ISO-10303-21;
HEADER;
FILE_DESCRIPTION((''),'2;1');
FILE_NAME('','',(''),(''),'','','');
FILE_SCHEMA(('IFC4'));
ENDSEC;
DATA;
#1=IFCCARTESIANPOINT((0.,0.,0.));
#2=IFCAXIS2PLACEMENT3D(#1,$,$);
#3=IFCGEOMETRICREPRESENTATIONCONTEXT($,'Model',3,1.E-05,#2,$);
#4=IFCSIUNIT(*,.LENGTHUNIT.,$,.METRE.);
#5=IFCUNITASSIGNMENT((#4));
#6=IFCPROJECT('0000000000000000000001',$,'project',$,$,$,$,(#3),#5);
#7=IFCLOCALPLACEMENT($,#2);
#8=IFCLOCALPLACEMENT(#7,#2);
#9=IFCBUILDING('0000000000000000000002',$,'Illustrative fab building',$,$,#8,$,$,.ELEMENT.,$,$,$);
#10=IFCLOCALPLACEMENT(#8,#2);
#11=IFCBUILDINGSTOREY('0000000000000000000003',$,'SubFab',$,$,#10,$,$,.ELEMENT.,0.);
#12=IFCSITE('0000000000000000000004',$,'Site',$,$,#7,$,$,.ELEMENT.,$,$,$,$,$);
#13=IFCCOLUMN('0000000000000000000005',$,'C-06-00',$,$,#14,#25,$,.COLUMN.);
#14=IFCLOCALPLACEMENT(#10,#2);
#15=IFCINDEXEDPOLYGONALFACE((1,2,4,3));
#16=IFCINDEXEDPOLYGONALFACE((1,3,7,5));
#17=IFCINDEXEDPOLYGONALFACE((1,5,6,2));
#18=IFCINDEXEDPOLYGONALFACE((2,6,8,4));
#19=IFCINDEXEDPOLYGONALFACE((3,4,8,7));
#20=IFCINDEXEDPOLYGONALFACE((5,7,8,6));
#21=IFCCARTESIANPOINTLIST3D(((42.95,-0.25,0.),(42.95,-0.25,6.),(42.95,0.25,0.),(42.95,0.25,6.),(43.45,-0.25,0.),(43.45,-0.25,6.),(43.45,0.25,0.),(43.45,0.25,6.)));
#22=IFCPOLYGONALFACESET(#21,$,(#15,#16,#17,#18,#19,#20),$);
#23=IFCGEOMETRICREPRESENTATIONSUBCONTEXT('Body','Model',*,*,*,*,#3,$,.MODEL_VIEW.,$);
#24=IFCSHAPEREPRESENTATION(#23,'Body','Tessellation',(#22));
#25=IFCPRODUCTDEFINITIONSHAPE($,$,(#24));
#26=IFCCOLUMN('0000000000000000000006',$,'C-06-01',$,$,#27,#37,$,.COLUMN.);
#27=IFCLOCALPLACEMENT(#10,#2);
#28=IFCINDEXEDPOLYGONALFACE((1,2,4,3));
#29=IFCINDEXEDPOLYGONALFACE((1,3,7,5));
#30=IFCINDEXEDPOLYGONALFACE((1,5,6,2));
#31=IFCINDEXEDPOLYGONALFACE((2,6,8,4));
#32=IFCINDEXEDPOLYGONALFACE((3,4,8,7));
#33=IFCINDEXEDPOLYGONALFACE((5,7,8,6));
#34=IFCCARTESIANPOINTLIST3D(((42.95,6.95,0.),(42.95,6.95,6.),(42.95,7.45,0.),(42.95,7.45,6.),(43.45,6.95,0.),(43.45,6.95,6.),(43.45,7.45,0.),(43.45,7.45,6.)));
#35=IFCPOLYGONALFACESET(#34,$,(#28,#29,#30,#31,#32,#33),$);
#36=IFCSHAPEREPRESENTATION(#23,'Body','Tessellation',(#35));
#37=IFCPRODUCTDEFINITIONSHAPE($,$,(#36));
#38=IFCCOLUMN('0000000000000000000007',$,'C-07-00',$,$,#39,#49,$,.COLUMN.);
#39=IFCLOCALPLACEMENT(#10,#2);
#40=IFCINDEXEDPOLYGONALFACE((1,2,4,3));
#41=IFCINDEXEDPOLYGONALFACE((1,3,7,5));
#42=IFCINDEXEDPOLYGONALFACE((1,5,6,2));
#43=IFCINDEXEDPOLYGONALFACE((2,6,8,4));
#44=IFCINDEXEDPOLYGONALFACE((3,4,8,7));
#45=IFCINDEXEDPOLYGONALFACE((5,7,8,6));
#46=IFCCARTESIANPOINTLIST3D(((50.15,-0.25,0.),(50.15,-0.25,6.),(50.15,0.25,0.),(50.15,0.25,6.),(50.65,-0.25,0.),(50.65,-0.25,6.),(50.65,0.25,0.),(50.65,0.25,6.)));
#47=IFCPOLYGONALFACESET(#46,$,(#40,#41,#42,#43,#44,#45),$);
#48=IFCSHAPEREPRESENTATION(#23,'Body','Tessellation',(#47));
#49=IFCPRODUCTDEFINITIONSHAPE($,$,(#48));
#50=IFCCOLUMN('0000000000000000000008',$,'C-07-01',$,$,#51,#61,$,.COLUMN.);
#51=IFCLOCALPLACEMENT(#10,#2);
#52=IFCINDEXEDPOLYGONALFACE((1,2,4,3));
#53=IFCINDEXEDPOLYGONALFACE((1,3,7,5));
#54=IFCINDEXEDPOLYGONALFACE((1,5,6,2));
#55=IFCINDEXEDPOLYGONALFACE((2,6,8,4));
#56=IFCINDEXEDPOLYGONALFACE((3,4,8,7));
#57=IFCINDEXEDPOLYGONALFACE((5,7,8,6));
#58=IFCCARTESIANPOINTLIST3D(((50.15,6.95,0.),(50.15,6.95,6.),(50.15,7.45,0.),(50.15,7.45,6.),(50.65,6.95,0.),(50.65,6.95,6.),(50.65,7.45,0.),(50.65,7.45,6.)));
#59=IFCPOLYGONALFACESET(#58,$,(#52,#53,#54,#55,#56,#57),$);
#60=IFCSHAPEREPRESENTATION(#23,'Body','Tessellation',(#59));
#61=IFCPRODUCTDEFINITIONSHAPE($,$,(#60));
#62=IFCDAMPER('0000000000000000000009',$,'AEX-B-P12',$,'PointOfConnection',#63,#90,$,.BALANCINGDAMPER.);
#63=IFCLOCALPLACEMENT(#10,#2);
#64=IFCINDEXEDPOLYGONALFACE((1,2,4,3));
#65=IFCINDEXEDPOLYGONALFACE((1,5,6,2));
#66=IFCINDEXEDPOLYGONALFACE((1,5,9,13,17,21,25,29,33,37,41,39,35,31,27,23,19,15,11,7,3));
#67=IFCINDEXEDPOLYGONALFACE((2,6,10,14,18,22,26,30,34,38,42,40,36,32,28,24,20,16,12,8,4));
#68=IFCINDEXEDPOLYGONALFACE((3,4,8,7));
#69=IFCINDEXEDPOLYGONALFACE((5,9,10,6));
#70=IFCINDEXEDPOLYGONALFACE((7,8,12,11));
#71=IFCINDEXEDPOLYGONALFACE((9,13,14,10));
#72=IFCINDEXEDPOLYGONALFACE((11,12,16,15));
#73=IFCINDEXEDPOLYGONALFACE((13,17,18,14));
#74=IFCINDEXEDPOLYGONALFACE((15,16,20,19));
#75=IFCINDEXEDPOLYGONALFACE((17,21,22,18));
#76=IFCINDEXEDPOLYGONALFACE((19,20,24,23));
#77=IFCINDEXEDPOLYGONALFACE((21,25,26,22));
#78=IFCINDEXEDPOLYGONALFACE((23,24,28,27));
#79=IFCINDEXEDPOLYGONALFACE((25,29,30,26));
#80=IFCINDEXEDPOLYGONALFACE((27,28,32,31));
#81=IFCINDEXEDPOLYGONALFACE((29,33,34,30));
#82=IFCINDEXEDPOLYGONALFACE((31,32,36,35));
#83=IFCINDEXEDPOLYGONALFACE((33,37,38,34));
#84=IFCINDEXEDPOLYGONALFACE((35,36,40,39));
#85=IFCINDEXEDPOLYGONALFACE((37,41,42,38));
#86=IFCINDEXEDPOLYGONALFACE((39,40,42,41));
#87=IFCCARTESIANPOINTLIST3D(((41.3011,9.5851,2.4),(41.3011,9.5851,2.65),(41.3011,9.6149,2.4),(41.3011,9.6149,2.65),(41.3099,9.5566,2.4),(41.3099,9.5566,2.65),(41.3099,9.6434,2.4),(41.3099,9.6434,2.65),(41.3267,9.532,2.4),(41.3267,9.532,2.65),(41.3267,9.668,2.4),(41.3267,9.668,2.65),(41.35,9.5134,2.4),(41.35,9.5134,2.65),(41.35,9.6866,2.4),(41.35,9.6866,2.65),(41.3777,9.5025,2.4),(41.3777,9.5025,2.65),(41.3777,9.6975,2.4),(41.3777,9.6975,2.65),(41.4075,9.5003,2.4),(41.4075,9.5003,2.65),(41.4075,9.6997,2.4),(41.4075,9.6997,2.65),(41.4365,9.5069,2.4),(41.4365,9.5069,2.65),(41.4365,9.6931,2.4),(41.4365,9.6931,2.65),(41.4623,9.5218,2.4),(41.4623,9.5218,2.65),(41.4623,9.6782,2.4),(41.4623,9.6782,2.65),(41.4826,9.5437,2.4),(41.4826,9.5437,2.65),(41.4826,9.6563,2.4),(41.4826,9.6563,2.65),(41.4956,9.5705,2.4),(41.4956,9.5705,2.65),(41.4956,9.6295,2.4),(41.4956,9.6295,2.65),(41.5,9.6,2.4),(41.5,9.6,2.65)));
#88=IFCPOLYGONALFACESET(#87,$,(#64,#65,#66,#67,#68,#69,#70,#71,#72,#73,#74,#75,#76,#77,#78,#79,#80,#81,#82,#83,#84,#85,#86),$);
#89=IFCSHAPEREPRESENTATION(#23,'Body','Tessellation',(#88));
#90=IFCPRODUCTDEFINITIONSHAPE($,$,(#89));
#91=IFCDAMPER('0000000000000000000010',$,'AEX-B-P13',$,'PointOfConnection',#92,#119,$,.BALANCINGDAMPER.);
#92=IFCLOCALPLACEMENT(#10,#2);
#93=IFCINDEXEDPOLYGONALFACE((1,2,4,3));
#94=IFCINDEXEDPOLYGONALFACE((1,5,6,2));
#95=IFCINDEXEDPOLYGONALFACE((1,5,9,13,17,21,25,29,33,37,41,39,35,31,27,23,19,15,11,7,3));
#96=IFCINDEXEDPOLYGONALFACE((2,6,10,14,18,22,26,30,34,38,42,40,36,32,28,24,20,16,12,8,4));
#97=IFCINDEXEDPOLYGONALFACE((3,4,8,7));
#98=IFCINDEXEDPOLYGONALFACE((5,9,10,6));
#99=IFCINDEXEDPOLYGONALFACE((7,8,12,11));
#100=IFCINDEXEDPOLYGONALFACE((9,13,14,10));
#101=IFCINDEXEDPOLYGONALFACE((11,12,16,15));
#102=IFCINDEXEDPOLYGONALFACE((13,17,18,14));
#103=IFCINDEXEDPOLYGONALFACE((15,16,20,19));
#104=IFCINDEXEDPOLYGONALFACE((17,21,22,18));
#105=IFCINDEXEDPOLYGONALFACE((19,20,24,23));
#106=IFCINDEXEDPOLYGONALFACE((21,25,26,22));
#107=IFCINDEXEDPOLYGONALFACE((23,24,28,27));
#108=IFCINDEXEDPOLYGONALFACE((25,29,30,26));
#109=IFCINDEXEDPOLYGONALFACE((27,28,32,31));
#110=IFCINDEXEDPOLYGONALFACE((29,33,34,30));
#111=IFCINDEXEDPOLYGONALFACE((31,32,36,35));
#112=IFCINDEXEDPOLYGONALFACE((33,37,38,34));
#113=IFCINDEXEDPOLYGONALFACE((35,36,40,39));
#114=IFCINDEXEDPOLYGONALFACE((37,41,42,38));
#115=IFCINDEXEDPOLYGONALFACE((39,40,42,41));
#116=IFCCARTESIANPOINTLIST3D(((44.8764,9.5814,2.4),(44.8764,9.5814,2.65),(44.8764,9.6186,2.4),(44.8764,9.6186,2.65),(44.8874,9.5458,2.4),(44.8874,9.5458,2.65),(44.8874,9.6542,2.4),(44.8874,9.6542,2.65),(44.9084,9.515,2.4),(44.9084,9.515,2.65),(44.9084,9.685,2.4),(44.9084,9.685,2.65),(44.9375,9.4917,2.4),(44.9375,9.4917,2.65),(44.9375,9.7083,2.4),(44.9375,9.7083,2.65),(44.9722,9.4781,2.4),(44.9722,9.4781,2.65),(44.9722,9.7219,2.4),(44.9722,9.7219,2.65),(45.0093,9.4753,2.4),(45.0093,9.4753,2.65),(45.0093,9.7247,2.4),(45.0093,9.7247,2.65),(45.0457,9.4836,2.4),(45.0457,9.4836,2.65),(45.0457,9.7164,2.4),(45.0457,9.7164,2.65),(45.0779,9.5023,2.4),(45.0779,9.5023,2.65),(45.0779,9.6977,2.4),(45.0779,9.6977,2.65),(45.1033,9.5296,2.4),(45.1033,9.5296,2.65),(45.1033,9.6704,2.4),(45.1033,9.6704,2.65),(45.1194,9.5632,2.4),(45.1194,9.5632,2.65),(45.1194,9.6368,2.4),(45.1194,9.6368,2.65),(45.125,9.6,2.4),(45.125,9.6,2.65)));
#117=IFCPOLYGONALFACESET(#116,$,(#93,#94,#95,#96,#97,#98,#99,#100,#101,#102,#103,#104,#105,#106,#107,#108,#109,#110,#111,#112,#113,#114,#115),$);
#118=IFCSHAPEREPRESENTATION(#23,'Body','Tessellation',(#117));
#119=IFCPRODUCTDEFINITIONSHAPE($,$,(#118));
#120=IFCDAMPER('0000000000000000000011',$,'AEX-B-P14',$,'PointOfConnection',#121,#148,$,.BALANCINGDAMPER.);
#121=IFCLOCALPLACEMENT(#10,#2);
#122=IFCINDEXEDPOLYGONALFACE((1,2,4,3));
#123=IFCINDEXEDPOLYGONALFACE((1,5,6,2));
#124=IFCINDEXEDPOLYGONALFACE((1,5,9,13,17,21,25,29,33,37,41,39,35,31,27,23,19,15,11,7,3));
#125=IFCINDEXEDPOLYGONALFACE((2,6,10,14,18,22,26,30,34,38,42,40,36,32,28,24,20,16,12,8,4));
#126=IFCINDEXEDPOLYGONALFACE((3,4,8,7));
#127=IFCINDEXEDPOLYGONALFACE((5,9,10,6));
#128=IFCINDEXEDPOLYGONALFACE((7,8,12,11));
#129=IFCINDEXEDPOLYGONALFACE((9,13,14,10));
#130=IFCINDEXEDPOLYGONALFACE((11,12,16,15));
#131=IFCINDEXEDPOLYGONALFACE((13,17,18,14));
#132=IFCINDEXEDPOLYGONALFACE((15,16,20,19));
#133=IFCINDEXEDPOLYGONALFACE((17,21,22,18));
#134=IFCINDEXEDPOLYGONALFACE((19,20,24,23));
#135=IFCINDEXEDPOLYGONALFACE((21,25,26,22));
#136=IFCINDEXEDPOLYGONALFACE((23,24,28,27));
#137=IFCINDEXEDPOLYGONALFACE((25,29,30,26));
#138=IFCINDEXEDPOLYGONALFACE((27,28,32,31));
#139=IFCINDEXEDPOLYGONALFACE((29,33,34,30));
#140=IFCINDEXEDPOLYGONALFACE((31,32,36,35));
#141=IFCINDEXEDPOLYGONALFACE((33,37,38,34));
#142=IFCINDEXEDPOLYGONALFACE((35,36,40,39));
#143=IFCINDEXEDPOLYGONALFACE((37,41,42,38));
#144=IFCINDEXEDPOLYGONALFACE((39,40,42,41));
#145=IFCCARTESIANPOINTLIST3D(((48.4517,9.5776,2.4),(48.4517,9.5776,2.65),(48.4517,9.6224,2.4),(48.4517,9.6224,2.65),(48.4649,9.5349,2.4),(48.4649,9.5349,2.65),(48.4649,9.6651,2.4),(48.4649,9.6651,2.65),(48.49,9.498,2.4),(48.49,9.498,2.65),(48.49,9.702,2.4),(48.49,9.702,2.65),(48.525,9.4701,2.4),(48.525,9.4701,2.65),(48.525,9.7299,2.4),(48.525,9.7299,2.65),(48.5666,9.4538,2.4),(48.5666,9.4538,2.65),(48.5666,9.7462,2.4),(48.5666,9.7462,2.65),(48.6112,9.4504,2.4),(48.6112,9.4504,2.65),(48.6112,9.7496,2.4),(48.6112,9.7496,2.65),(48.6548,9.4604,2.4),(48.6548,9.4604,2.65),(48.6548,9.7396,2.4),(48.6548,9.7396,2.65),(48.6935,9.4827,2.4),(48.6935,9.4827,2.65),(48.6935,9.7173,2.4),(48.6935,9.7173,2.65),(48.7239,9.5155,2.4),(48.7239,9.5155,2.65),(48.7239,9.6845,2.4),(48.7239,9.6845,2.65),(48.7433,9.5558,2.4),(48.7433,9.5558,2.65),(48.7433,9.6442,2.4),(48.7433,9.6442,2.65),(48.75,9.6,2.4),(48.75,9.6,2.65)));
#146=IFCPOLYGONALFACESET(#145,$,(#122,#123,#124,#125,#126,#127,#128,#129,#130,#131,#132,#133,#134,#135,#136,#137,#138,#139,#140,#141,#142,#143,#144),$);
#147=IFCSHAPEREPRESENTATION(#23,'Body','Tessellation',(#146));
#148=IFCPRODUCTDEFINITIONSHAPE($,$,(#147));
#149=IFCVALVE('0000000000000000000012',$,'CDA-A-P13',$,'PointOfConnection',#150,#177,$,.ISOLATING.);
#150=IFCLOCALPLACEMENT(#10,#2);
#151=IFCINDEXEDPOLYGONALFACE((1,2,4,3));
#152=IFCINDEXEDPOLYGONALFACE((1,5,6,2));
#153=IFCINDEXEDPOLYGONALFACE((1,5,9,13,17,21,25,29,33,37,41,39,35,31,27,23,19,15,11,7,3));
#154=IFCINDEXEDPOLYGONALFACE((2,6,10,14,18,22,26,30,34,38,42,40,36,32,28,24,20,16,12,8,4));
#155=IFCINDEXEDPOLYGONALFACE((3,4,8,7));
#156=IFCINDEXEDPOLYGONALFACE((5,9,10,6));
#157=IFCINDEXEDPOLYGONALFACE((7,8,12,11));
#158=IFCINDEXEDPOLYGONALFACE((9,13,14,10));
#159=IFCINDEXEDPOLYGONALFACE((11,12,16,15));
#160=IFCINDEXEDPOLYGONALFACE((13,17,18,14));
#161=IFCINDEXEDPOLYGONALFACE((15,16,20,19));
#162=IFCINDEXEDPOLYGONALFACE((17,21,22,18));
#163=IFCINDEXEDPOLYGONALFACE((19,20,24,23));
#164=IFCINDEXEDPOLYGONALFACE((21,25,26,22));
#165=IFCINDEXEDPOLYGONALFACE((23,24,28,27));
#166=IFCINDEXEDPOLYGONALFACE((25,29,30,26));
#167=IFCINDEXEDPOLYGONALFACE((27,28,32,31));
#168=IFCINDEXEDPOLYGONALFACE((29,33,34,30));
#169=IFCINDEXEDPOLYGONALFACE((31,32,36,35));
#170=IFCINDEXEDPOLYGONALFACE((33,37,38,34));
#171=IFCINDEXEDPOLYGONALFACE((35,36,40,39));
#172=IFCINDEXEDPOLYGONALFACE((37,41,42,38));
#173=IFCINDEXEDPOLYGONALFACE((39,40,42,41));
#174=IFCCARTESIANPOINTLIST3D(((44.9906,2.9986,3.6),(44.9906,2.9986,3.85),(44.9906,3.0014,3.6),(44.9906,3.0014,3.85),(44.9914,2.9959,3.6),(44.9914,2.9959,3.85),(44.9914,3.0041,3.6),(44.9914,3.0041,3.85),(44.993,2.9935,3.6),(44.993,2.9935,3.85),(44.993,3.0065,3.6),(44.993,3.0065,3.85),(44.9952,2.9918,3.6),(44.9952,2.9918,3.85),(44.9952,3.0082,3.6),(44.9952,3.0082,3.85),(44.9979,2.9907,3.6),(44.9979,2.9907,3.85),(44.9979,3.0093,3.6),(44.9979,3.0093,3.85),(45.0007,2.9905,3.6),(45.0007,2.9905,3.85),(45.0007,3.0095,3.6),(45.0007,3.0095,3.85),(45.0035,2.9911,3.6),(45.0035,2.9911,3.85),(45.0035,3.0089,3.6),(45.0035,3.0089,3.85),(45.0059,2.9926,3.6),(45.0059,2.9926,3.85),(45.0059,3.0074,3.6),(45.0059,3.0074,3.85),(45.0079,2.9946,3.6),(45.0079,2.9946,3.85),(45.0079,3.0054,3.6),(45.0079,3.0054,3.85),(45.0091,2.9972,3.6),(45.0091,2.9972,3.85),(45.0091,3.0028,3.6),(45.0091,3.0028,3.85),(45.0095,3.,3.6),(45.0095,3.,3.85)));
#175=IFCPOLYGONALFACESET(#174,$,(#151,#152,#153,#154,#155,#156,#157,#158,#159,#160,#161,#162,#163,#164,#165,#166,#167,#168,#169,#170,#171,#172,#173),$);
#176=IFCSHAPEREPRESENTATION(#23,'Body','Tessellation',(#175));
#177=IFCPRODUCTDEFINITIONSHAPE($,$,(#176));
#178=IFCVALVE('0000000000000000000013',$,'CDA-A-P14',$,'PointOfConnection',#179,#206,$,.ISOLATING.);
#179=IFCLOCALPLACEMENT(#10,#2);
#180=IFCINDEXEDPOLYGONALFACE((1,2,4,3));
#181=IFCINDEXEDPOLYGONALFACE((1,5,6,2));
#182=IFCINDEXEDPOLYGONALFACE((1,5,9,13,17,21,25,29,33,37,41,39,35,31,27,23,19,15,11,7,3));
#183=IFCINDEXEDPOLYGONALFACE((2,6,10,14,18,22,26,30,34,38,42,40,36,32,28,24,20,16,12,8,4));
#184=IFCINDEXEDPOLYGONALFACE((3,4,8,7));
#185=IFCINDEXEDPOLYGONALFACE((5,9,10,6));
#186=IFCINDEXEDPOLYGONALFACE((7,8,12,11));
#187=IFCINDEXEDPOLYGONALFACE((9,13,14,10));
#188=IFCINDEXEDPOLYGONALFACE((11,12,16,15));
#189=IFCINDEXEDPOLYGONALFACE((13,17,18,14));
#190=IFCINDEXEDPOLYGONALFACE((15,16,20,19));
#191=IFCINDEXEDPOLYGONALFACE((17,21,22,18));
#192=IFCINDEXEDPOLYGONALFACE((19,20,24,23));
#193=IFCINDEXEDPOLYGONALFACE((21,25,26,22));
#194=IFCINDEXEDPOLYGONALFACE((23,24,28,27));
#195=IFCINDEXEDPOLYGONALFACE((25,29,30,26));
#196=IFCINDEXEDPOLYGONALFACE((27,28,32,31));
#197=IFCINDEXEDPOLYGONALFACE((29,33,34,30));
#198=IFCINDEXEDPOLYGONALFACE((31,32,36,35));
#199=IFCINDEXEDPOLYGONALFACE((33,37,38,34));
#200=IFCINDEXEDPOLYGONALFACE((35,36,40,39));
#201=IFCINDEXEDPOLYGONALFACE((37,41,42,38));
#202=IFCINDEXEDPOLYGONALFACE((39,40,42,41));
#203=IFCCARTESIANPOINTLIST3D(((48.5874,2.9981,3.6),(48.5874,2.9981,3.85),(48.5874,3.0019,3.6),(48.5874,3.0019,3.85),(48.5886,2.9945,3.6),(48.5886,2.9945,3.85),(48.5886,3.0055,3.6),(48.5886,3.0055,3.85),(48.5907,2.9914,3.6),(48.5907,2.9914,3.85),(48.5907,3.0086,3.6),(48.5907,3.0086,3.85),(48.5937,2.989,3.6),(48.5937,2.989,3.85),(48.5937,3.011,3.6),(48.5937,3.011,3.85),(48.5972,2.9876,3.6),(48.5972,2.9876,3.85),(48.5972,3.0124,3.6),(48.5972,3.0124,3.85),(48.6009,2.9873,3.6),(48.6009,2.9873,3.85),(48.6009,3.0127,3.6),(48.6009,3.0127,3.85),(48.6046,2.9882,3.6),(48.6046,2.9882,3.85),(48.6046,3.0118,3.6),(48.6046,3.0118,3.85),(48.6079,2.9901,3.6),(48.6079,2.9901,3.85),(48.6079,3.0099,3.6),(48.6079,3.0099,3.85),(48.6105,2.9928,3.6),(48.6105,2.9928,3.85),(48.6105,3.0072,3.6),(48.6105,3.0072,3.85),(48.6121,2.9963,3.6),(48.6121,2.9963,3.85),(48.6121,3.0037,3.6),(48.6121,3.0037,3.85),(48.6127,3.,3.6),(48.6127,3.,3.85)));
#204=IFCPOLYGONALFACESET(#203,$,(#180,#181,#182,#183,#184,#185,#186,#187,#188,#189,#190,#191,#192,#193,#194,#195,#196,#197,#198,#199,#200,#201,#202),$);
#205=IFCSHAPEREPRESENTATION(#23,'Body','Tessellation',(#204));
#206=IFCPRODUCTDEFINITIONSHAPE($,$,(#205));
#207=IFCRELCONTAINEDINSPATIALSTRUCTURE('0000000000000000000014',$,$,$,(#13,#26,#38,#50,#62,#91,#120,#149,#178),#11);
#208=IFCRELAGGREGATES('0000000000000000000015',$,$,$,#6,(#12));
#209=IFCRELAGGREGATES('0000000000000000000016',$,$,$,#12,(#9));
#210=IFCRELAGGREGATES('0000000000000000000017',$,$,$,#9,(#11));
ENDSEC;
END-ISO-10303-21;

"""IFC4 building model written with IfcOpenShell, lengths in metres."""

from ifc_helpers import new_model, entity, si_unit, frame, origin, origin_2d, place, context, subcontext, project, spatial, rectangle, extrude, element, save


model = new_model("IFC4")

# Units and contexts
model_context = context("Model", 3, precision=1e-05, world=origin())
body_context = subcontext(model_context, "Body", "Model", "MODEL_VIEW")
ifc_project = project(units=[si_unit("LENGTHUNIT", "METRE")], contexts=[model_context])

# Site, building, storey
site_placement = place(None, origin())
site = spatial("IfcSite", under=ifc_project, at=site_placement, Name="Site", CompositionType="ELEMENT")
building_placement = place(site_placement, origin())
building = spatial("IfcBuilding", under=site, at=building_placement, Name="Illustrative fab building", CompositionType="ELEMENT")
storey_placement = place(building_placement, origin())
storey = spatial("IfcBuildingStorey", under=building, at=storey_placement, Name="SubFab", CompositionType="ELEMENT", Elevation=0.0)

# Columns
for number, where, name in (
    (1, (43.2, 0.0, 0.0), "C-06-00"),
    (2, (43.2, 7.2, 0.0), "C-06-01"),
    (3, (50.4, 0.0, 0.0), "C-07-00"),
    (4, (50.4, 7.2, 0.0), "C-07-01"),
):
    element("IfcColumn", number, at=place(storey_placement, frame(where)), inside=storey, Name=name, PredefinedType="COLUMN", context=body_context, shape_type="SweptSolid", body=[
        extrude(rectangle(XDim=0.5, YDim=0.5, at=origin_2d()), origin(), (0.0, 0.0, 1.0), 6.0),
    ])

# Dampers
damper_1_placement = place(storey_placement, frame((41.4, 9.6, 2.4)))
element("IfcDamper", 5, at=damper_1_placement, inside=storey, Name="AEX-B-P12", ObjectType="PointOfConnection", PredefinedType="BALANCINGDAMPER", context=body_context, shape_type="AdvancedSweptSolid", body=[
    entity("IfcSweptDiskSolid", entity("IfcPolyline", [entity("IfcCartesianPoint", [0.0, 0.0, 0.0]), entity("IfcCartesianPoint", [0.0, 0.0, 0.25])]), 0.1),
])
damper_2_placement = place(storey_placement, frame((45.0, 9.6, 2.4)))
element("IfcDamper", 6, at=damper_2_placement, inside=storey, Name="AEX-B-P13", ObjectType="PointOfConnection", PredefinedType="BALANCINGDAMPER", context=body_context, shape_type="AdvancedSweptSolid", body=[
    entity("IfcSweptDiskSolid", entity("IfcPolyline", [entity("IfcCartesianPoint", [0.0, 0.0, 0.0]), entity("IfcCartesianPoint", [0.0, 0.0, 0.25])]), 0.125),
])
damper_3_placement = place(storey_placement, frame((48.6, 9.6, 2.4)))
element("IfcDamper", 7, at=damper_3_placement, inside=storey, Name="AEX-B-P14", ObjectType="PointOfConnection", PredefinedType="BALANCINGDAMPER", context=body_context, shape_type="AdvancedSweptSolid", body=[
    entity("IfcSweptDiskSolid", entity("IfcPolyline", [entity("IfcCartesianPoint", [0.0, 0.0, 0.0]), entity("IfcCartesianPoint", [0.0, 0.0, 0.25])]), 0.15),
])

# Valves
valve_1_placement = place(storey_placement, frame((45.0, 3.0, 3.6)))
element("IfcValve", 8, at=valve_1_placement, inside=storey, Name="CDA-A-P13", ObjectType="PointOfConnection", PredefinedType="ISOLATING", context=body_context, shape_type="AdvancedSweptSolid", body=[
    entity("IfcSweptDiskSolid", entity("IfcPolyline", [entity("IfcCartesianPoint", [0.0, 0.0, 0.0]), entity("IfcCartesianPoint", [0.0, 0.0, 0.25])]), 0.0095),
])
valve_2_placement = place(storey_placement, frame((48.6, 3.0, 3.6)))
element("IfcValve", 9, at=valve_2_placement, inside=storey, Name="CDA-A-P14", ObjectType="PointOfConnection", PredefinedType="ISOLATING", context=body_context, shape_type="AdvancedSweptSolid", body=[
    entity("IfcSweptDiskSolid", entity("IfcPolyline", [entity("IfcCartesianPoint", [0.0, 0.0, 0.0]), entity("IfcCartesianPoint", [0.0, 0.0, 0.25])]), 0.0127),
])

save(model, "model.ifc")
